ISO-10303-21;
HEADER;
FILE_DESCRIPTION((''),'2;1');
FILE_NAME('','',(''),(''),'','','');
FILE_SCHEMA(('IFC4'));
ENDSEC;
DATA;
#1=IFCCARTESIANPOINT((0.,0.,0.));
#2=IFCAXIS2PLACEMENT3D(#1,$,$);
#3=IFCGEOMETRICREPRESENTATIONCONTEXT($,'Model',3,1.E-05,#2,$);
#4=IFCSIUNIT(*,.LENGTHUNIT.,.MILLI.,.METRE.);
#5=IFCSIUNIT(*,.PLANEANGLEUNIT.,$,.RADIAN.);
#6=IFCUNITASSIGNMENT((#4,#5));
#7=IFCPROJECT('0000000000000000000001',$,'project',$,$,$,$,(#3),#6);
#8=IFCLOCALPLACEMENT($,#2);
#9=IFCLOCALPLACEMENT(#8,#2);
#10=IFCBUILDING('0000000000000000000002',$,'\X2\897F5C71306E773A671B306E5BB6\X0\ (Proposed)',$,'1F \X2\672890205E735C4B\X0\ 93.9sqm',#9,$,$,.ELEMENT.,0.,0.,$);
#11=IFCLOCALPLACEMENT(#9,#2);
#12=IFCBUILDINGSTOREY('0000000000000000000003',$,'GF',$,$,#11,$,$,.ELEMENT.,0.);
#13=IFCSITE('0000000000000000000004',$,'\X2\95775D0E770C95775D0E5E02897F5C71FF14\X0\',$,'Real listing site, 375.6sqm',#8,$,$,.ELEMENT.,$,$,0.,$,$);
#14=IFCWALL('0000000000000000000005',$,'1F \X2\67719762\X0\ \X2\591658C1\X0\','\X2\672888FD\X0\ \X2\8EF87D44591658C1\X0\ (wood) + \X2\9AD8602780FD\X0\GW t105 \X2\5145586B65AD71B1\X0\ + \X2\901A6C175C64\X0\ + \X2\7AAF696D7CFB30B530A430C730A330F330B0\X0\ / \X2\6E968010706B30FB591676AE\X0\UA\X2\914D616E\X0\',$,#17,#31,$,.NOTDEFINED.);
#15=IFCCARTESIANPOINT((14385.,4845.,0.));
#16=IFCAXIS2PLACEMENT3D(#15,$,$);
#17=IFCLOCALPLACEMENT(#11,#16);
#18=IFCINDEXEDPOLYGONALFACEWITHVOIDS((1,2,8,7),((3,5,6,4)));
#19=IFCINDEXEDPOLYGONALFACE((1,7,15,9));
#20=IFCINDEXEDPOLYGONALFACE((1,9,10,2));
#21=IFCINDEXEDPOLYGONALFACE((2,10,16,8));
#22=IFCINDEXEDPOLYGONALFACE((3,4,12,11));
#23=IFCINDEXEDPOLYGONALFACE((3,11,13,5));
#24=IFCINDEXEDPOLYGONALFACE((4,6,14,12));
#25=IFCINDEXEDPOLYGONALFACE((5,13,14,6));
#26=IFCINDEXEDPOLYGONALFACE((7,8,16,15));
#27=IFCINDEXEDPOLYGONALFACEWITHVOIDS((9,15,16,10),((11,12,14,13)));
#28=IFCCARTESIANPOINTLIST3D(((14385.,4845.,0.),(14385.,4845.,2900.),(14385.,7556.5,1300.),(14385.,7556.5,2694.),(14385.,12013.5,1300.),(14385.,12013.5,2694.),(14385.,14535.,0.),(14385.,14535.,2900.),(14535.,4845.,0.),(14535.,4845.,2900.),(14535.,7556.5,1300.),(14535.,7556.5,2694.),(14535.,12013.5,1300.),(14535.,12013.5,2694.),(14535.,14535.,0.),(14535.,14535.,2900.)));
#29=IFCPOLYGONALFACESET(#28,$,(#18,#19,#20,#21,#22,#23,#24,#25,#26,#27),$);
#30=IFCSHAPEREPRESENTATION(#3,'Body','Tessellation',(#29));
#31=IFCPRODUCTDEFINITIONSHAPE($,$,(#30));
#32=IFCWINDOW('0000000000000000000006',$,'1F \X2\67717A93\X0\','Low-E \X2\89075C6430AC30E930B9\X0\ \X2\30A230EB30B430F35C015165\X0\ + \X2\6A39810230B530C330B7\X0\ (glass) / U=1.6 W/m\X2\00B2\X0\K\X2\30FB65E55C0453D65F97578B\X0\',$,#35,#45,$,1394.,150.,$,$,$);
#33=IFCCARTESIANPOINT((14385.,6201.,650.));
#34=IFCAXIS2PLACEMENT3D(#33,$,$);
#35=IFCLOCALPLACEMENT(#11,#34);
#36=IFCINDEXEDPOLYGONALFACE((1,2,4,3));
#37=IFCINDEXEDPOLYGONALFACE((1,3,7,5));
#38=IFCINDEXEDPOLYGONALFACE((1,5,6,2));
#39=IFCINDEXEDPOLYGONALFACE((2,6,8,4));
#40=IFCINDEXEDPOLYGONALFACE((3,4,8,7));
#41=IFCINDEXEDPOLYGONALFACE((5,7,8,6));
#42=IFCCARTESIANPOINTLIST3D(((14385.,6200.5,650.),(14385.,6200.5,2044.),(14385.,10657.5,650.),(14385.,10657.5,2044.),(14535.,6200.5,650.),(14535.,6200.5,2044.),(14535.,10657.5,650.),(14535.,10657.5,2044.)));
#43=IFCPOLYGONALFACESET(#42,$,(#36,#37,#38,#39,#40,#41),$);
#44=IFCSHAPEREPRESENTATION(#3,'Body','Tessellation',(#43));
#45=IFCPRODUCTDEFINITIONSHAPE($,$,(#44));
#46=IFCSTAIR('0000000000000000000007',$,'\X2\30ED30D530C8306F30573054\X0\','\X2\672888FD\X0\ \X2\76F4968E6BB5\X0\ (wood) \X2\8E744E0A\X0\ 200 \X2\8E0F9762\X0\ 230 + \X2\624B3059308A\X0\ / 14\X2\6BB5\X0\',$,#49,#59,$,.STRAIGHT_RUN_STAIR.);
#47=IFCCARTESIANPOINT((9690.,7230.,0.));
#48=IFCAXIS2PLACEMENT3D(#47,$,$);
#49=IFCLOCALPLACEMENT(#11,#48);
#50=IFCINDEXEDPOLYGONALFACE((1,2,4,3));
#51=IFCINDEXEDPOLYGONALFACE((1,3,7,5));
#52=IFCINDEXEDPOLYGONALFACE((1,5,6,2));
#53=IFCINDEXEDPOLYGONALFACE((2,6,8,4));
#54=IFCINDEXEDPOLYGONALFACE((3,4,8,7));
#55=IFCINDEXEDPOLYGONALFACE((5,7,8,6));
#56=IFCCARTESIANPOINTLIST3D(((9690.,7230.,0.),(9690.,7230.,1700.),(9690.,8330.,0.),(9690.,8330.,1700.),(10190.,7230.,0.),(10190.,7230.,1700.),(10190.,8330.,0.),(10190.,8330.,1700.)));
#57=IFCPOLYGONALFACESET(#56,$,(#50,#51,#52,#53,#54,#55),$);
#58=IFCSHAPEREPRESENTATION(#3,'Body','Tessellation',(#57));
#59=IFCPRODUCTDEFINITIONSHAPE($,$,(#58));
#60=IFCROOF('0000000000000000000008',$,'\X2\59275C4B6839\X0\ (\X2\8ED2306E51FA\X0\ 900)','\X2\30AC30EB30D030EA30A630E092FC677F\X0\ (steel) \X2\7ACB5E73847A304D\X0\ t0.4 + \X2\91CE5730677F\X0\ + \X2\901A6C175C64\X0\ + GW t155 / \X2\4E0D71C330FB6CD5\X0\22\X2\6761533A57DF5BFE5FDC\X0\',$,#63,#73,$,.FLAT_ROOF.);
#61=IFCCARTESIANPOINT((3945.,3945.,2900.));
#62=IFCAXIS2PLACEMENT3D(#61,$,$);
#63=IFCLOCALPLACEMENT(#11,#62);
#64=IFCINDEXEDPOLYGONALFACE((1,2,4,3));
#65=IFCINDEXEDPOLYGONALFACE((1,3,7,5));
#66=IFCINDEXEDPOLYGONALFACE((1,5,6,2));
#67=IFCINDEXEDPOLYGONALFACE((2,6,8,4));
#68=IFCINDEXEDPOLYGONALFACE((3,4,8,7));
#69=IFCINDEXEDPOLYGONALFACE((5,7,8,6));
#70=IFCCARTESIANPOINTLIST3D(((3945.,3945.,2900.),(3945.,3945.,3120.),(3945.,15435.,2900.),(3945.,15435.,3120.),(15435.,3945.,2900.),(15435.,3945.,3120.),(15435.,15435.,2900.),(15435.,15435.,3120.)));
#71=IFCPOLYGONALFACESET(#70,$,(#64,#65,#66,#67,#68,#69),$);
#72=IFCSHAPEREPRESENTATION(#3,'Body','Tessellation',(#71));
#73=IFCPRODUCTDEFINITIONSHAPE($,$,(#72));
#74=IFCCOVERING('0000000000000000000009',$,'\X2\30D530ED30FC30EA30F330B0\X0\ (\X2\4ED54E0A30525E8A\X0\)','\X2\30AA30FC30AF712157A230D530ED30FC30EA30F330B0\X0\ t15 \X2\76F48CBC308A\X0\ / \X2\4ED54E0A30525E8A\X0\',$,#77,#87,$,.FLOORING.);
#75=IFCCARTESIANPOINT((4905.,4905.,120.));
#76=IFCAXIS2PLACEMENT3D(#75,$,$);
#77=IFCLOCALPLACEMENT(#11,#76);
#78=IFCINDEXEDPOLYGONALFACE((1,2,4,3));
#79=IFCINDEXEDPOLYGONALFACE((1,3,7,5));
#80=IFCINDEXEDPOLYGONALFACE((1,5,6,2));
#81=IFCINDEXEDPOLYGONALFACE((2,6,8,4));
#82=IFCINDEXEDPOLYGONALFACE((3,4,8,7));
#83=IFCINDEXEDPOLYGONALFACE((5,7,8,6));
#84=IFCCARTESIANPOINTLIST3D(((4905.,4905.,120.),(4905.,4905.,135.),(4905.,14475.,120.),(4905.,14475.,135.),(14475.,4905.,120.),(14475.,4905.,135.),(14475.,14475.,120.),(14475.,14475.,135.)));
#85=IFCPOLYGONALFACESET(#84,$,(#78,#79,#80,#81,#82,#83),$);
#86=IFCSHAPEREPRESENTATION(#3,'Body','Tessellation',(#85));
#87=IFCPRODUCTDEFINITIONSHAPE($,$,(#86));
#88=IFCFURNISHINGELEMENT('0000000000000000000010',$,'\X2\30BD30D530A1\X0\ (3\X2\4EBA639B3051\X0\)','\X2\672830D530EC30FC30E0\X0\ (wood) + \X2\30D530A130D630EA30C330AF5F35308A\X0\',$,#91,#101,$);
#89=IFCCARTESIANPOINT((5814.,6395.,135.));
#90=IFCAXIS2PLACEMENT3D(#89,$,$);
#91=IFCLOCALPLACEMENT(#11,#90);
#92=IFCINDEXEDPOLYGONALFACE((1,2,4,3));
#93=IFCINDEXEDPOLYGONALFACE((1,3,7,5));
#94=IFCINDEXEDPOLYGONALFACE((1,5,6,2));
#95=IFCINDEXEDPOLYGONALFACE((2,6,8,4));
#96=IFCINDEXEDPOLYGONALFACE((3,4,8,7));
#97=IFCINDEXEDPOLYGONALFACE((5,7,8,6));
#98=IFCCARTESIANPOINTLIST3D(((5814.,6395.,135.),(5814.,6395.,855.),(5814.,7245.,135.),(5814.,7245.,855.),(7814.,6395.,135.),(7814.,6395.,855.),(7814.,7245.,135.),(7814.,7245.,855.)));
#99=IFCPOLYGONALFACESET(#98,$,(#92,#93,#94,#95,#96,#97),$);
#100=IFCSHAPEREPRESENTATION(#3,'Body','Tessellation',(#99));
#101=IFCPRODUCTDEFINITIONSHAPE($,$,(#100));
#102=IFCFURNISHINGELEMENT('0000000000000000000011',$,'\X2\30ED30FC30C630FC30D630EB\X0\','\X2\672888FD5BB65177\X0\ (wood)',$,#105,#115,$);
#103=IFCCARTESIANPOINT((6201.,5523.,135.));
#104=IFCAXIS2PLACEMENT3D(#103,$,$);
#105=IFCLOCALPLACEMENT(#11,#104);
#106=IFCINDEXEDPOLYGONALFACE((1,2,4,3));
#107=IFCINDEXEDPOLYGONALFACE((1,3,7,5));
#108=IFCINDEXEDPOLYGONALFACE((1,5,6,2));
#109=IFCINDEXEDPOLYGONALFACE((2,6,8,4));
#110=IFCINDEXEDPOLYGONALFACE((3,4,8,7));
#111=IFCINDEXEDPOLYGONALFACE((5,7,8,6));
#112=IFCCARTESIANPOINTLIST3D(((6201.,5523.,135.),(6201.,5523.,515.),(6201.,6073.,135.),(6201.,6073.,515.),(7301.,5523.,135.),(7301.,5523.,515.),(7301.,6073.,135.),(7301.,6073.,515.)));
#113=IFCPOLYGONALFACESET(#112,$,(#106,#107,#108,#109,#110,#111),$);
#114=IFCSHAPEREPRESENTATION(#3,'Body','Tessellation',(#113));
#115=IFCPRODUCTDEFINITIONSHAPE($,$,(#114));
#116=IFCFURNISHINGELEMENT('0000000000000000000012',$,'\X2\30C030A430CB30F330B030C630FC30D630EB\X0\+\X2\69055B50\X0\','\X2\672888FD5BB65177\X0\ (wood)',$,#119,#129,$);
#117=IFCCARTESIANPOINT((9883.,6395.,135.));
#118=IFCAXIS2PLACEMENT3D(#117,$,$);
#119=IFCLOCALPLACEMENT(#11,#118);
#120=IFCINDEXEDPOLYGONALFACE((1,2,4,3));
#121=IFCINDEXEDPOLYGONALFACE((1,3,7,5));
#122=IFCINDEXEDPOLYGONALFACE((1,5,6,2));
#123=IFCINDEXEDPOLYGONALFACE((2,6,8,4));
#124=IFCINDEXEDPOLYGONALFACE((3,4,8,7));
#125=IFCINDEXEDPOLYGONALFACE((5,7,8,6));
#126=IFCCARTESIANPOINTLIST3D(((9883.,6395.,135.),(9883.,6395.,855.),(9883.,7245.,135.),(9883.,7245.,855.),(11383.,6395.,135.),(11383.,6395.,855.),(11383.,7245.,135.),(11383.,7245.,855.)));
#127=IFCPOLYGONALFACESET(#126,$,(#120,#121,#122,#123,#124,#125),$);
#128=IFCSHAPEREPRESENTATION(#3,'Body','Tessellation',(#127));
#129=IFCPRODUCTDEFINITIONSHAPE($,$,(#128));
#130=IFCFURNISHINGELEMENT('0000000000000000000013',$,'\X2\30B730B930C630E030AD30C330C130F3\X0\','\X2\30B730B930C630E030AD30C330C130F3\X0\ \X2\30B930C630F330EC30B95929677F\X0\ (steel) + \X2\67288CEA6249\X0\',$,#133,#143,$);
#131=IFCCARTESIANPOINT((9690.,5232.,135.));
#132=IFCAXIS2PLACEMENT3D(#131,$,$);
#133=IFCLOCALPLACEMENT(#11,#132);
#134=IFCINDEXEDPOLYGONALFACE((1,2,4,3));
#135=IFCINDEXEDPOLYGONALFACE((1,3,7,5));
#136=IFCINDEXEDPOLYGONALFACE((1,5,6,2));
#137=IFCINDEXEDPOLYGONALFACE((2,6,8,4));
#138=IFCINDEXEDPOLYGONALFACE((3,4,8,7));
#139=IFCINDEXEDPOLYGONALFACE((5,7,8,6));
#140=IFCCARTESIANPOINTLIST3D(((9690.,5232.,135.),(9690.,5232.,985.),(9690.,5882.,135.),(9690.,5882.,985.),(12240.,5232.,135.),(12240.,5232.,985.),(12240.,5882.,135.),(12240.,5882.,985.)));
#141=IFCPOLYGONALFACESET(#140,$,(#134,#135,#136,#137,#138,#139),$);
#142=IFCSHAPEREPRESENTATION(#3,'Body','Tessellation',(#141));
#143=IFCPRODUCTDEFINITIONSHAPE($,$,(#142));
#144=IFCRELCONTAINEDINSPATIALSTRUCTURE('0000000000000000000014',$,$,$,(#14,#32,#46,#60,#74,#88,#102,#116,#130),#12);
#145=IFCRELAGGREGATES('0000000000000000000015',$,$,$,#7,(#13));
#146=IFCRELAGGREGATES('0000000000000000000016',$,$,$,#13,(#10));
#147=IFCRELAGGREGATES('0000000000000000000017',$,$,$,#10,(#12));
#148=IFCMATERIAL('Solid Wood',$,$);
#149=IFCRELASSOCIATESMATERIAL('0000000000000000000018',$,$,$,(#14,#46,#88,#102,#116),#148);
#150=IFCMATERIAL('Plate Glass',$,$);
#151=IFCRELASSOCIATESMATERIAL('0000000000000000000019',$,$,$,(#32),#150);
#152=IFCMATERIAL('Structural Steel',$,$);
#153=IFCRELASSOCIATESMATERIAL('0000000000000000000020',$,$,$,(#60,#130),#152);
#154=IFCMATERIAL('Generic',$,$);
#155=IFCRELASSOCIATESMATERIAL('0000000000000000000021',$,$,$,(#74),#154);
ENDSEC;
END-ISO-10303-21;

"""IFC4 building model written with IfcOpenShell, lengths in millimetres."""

from ifc_helpers import new_model, si_unit, frame, frame_2d, origin, place, context, project, spatial, rectangle, extrude, material, element, fill, save


model = new_model("IFC4")

# Units and contexts
model_context = context("Model", 3, precision=1e-05, world=origin())
ifc_project = project(units=[si_unit("LENGTHUNIT", "METRE", prefix="MILLI"), si_unit("PLANEANGLEUNIT", "RADIAN")], contexts=[model_context])

# Site, building, storey
site_placement = place(None, origin())
site = spatial("IfcSite", under=ifc_project, at=site_placement, Name="長崎県長崎市西山４", ObjectType="Real listing site, 375.6sqm", CompositionType="ELEMENT", RefElevation=0.0)
building_placement = place(site_placement, origin())
building = spatial("IfcBuilding", under=site, at=building_placement, Name="西山の眺望の家 (Proposed)", ObjectType="1F 木造平屋 93.9sqm", CompositionType="ELEMENT", ElevationOfRefHeight=0.0, ElevationOfTerrain=0.0)
storey_placement = place(building_placement, origin())
storey = spatial("IfcBuildingStorey", under=building, at=storey_placement, Name="GF", CompositionType="ELEMENT", Elevation=0.0)

# Shared definitions
ifc_material_1 = material(Name="Solid Wood")

# Shared definitions
ifc_material_2 = material(Name="Plate Glass")

# Wall, opening, window
wall_1_placement = place(storey_placement, frame((14385.0, 4845.0, 0.0)))
wall_1 = element("IfcWall", 1, at=wall_1_placement, inside=storey, material=ifc_material_1, Name="1F 東面 外壁", Description="木製 軸組外壁 (wood) + 高性能GW t105 充填断熱 + 通気層 + 窯業系サイディング / 準耐火・外皮UA配慮", PredefinedType="NOTDEFINED", context=model_context, shape_type="SweptSolid", body=[
    extrude(rectangle(XDim=150.0, YDim=9690.0, at=frame_2d((75.0, 4845.0))), frame((14385.0, 4845.0, 0.0)), (0.0, 0.0, 1.0), 2900.0),
])
opening_1_placement = place(storey_placement, frame((14385.0, 6201.0, 650.0)))
opening_1 = element("IfcOpeningElement", 2, at=opening_1_placement, cuts=wall_1, PredefinedType="NOTDEFINED", context=model_context, shape_type="SweptSolid", body=[
    extrude(rectangle(XDim=150.0, YDim=4457.0, at=frame_2d((75.0, 2228.0))), frame((14385.0, 6201.0, 650.0)), (0.0, 0.0, 1.0), 1394.0),
])
window_1_placement = place(storey_placement, frame((14385.0, 6201.0, 650.0)))
window_1 = element("IfcWindow", 3, at=window_1_placement, inside=storey, material=ifc_material_2, Name="1F 東窓", Description="Low-E 複層ガラス アルゴン封入 + 樹脂サッシ (glass) / U=1.6 W/m²K・日射取得型", OverallHeight=1394.0, OverallWidth=150.0, context=model_context, shape_type="SweptSolid", body=[
    extrude(rectangle(XDim=150.0, YDim=4457.0, at=frame_2d((75.0, 2228.0))), frame((14385.0, 6201.0, 650.0)), (0.0, 0.0, 1.0), 1394.0),
])
fill(opening_1, window_1)

# Stair
stair_placement = place(storey_placement, frame((9690.0, 7230.0, 0.0)))
element("IfcStair", 4, at=stair_placement, inside=storey, material=ifc_material_1, Name="ロフトはしご", Description="木製 直階段 (wood) 蹴上 200 踏面 230 + 手すり / 14段", PredefinedType="STRAIGHT_RUN_STAIR", context=model_context, shape_type="SweptSolid", body=[
    extrude(rectangle(XDim=500.0, YDim=1100.0, at=frame_2d((250.0, 550.0))), frame((9690.0, 7230.0, 0.0)), (0.0, 0.0, 1.0), 1700.0),
])

# Roof
ifc_material_3 = material(Name="Structural Steel")
roof_placement = place(storey_placement, frame((3945.0, 3945.0, 2900.0)))
element("IfcRoof", 5, at=roof_placement, inside=storey, material=ifc_material_3, Name="大屋根 (軒の出 900)", Description="ガルバリウム鋼板 (steel) 立平葺き t0.4 + 野地板 + 通気層 + GW t155 / 不燃・法22条区域対応", PredefinedType="FLAT_ROOF", context=model_context, shape_type="SweptSolid", body=[
    extrude(rectangle(XDim=11490.0, YDim=11490.0, at=frame_2d((5745.0, 5745.0))), frame((3945.0, 3945.0, 2900.0)), (0.0, 0.0, 1.0), 220.0),
])

# Covering
ifc_material_4 = material(Name="Generic")
covering_placement = place(storey_placement, frame((4905.0, 4905.0, 120.0)))
element("IfcCovering", 6, at=covering_placement, inside=storey, material=ifc_material_4, Name="フローリング (仕上げ床)", Description="オーク無垢フローリング t15 直貼り / 仕上げ床", PredefinedType="FLOORING", context=model_context, shape_type="SweptSolid", body=[
    extrude(rectangle(XDim=9570.0, YDim=9570.0, at=frame_2d((4785.0, 4785.0))), frame((4905.0, 4905.0, 120.0)), (0.0, 0.0, 1.0), 15.0),
])

# Furnishing elements
furnishing_1_placement = place(storey_placement, frame((5814.0, 6395.0, 135.0)))
element("IfcFurnishingElement", 7, at=furnishing_1_placement, inside=storey, material=ifc_material_1, Name="ソファ (3人掛け)", Description="木フレーム (wood) + ファブリック張り", context=model_context, shape_type="SweptSolid", body=[
    extrude(rectangle(XDim=2000.0, YDim=850.0, at=frame_2d((1000.0, 425.0))), frame((5814.0, 6395.0, 135.0)), (0.0, 0.0, 1.0), 720.0),
])
furnishing_2_placement = place(storey_placement, frame((6201.0, 5523.0, 135.0)))
element("IfcFurnishingElement", 8, at=furnishing_2_placement, inside=storey, material=ifc_material_1, Name="ローテーブル", Description="木製家具 (wood)", context=model_context, shape_type="SweptSolid", body=[
    extrude(rectangle(XDim=1100.0, YDim=550.0, at=frame_2d((550.0, 275.0))), frame((6201.0, 5523.0, 135.0)), (0.0, 0.0, 1.0), 380.0),
])
furnishing_3_placement = place(storey_placement, frame((9883.0, 6395.0, 135.0)))
element("IfcFurnishingElement", 9, at=furnishing_3_placement, inside=storey, material=ifc_material_1, Name="ダイニングテーブル+椅子", Description="木製家具 (wood)", context=model_context, shape_type="SweptSolid", body=[
    extrude(rectangle(XDim=1500.0, YDim=850.0, at=frame_2d((750.0, 425.0))), frame((9883.0, 6395.0, 135.0)), (0.0, 0.0, 1.0), 720.0),
])
furnishing_4_placement = place(storey_placement, frame((9690.0, 5232.0, 135.0)))
element("IfcFurnishingElement", 10, at=furnishing_4_placement, inside=storey, material=ifc_material_3, Name="システムキッチン", Description="システムキッチン ステンレス天板 (steel) + 木質扉", context=model_context, shape_type="SweptSolid", body=[
    extrude(rectangle(XDim=2550.0, YDim=650.0, at=frame_2d((1275.0, 325.0))), frame((9690.0, 5232.0, 135.0)), (0.0, 0.0, 1.0), 850.0),
])

save(model, "model.ifc")
